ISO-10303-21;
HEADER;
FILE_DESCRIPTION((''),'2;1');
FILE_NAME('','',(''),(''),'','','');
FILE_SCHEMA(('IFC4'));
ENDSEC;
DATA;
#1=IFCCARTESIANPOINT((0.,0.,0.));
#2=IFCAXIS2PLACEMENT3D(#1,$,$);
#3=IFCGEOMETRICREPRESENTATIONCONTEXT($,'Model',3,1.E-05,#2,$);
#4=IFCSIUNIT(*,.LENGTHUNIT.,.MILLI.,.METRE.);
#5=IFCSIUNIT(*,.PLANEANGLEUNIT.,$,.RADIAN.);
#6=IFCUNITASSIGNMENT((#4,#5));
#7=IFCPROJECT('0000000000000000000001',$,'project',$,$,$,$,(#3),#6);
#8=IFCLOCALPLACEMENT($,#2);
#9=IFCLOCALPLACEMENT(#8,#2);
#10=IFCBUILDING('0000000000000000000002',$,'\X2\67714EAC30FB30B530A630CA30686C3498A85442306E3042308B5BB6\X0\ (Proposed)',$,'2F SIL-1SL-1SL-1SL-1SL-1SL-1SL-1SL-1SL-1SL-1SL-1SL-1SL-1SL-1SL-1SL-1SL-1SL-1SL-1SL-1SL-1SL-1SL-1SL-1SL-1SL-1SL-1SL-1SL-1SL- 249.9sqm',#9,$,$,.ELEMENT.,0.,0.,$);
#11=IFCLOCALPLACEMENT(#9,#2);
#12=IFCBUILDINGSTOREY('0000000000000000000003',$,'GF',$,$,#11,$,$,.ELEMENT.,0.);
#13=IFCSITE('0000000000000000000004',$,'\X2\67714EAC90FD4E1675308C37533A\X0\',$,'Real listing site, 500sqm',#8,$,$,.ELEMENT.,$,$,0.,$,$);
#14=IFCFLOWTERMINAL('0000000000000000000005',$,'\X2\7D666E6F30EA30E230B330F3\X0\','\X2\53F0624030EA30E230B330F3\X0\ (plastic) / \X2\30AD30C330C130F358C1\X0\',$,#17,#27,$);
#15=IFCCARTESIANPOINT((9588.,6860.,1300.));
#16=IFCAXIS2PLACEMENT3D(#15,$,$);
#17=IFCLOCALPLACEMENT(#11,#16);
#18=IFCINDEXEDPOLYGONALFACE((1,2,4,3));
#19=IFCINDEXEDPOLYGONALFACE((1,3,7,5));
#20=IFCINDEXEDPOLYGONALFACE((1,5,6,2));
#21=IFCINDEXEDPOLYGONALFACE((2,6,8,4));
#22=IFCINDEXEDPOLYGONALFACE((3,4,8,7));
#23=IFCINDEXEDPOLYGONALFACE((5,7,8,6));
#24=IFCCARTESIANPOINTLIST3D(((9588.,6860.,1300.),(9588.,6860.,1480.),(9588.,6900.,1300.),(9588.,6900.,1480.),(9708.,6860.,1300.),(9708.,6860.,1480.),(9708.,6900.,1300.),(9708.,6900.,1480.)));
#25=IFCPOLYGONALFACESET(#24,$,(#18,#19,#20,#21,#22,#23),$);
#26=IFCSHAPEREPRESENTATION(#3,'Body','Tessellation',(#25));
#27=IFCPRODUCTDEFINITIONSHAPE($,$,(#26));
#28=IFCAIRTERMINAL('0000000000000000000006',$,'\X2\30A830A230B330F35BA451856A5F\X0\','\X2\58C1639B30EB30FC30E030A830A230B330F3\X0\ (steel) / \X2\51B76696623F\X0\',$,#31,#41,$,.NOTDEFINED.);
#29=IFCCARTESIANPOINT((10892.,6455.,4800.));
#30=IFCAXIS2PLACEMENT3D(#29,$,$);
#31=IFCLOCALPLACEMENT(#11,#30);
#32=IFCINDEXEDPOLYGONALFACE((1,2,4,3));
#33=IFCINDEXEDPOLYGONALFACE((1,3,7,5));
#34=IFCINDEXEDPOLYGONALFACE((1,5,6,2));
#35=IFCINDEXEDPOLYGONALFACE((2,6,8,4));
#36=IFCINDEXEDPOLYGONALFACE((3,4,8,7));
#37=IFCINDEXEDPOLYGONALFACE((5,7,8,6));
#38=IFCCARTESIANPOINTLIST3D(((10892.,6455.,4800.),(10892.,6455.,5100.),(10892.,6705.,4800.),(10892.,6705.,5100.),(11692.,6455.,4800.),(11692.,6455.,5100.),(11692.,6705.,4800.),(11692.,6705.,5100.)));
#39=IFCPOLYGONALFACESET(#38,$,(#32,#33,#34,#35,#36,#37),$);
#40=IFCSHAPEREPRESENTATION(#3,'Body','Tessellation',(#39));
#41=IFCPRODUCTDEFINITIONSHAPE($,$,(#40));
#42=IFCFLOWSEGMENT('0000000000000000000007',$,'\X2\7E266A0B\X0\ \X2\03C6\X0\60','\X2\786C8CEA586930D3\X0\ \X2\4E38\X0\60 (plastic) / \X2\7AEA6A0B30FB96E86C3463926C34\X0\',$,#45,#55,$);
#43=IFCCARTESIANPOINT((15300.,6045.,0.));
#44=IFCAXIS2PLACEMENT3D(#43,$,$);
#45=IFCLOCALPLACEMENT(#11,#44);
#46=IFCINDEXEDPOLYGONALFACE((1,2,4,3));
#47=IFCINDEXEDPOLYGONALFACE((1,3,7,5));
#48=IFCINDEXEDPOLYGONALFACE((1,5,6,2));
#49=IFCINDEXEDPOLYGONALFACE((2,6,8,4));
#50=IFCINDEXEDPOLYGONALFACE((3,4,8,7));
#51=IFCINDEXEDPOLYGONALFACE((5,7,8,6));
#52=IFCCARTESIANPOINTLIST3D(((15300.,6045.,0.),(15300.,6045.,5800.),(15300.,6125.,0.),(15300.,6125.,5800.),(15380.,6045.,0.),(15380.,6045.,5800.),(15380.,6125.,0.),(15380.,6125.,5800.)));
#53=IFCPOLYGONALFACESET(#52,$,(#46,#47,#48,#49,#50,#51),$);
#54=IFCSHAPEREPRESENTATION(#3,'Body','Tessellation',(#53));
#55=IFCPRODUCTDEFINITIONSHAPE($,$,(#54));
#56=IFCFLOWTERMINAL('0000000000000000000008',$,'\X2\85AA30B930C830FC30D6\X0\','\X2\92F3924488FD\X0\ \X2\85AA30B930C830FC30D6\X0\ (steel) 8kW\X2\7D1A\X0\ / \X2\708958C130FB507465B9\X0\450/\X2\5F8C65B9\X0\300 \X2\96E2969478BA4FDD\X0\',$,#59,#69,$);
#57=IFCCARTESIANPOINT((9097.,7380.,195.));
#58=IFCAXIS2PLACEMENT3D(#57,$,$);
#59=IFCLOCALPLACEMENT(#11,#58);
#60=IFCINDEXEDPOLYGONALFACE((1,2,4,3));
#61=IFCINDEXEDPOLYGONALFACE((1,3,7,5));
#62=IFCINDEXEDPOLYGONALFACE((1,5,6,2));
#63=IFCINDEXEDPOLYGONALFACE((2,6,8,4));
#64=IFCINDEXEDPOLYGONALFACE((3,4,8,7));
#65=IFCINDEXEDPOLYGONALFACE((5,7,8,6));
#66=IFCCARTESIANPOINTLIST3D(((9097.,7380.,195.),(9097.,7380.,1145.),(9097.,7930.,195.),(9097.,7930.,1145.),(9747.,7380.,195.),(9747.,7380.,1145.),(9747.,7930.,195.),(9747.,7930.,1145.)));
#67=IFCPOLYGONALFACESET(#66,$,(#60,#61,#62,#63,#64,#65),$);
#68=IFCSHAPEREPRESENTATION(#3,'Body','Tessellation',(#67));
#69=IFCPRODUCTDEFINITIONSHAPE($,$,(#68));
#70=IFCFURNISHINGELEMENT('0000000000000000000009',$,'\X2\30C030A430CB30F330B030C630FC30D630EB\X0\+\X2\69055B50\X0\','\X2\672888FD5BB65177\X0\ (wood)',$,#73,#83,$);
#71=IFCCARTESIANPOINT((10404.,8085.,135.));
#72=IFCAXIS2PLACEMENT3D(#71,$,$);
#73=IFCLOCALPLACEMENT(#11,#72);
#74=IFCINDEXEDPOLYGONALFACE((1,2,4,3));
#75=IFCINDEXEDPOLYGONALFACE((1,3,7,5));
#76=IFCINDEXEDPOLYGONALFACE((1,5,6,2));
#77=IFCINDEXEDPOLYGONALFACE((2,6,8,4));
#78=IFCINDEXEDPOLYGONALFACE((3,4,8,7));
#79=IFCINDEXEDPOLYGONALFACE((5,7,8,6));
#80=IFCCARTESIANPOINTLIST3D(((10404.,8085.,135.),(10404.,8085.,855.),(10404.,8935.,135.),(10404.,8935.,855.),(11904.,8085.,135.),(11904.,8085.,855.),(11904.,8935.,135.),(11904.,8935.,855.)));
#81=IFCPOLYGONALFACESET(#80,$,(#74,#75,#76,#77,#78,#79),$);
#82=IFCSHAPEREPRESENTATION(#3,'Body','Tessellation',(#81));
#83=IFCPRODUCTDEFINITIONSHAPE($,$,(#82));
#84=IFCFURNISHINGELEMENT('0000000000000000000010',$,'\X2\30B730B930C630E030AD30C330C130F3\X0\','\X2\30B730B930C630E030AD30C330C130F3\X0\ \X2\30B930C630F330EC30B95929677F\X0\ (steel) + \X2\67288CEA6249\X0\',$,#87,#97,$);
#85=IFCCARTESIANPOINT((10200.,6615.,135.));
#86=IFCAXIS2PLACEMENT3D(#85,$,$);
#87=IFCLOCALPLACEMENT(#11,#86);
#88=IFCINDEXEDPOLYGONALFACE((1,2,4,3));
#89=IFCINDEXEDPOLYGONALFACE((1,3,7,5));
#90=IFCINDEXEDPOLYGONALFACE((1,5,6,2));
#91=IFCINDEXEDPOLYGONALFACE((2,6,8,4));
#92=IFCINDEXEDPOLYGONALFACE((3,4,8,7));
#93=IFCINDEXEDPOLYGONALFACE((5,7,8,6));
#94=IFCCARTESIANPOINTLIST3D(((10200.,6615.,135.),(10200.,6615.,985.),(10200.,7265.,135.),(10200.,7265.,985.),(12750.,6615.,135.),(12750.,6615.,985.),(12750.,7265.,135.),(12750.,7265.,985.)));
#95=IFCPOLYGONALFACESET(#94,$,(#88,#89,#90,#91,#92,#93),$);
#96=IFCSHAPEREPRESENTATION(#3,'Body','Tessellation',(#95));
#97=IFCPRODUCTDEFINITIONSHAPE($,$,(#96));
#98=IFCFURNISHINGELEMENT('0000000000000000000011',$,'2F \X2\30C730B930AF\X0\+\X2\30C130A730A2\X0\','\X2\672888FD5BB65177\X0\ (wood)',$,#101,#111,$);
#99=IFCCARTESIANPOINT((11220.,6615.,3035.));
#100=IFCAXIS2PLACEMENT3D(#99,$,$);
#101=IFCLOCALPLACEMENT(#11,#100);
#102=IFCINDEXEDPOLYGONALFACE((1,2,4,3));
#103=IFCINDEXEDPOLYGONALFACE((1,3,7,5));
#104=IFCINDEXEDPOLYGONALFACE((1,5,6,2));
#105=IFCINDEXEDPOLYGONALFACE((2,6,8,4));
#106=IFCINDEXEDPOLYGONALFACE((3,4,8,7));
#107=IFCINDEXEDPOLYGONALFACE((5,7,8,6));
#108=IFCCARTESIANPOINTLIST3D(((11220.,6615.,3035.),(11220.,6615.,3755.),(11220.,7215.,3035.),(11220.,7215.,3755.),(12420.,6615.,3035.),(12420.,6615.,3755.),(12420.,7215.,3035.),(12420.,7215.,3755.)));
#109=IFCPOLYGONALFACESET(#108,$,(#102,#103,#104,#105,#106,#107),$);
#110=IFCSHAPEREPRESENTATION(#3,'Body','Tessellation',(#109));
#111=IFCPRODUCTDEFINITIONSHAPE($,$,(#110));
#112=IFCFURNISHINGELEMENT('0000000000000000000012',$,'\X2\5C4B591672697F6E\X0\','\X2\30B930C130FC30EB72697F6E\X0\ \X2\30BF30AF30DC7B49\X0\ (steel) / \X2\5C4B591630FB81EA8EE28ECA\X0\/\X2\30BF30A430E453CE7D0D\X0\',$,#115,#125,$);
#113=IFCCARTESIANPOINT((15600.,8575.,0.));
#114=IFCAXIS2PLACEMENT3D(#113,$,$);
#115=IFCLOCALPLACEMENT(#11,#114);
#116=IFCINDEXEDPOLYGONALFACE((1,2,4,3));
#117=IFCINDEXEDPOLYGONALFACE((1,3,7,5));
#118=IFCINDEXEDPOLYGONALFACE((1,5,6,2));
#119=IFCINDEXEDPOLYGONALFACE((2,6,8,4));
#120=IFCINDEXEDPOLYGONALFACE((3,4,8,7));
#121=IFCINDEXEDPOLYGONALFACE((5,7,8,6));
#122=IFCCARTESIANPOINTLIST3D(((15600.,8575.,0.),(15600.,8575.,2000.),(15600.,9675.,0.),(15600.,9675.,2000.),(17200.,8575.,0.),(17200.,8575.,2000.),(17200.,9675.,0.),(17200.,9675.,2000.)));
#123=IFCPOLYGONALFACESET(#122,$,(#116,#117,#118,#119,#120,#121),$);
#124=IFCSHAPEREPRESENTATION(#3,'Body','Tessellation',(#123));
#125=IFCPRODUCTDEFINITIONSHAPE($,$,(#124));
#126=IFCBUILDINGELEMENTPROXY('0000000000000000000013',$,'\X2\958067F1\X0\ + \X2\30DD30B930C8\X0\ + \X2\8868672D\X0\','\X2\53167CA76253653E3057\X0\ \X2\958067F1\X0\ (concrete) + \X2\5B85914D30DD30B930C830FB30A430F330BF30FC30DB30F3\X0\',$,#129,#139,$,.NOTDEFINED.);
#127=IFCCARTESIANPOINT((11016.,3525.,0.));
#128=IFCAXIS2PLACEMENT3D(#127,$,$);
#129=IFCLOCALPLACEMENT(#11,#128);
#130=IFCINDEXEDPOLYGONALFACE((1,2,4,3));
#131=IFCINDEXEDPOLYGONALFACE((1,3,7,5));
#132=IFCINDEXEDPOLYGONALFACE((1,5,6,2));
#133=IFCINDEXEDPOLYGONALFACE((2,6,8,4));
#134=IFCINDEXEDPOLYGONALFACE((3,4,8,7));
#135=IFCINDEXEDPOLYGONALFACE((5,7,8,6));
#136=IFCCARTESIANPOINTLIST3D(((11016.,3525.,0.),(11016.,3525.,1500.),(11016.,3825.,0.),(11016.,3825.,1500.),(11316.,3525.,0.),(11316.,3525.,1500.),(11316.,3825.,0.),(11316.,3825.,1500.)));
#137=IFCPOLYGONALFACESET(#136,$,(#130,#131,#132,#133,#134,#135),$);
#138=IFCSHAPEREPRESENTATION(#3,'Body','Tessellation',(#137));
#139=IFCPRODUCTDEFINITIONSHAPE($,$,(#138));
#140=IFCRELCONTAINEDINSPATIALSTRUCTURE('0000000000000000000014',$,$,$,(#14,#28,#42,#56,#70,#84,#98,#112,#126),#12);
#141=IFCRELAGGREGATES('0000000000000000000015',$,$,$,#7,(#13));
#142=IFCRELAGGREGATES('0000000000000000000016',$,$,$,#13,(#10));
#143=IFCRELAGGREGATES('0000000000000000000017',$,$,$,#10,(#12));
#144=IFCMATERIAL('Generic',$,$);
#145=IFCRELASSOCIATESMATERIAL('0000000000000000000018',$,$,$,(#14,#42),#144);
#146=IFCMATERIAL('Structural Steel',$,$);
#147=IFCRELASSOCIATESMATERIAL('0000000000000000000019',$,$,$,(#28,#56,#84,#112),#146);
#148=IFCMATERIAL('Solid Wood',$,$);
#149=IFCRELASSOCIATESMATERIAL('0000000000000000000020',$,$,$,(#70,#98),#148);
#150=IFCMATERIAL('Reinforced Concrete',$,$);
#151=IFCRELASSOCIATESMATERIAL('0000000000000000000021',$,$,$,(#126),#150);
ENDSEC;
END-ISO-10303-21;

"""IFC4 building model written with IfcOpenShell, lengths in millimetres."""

from ifc_helpers import new_model, si_unit, frame, frame_2d, origin, place, context, project, spatial, rectangle, extrude, material, element, save


model = new_model("IFC4")

# Units and contexts
model_context = context("Model", 3, precision=1e-05, world=origin())
ifc_project = project(units=[si_unit("LENGTHUNIT", "METRE", prefix="MILLI"), si_unit("PLANEANGLEUNIT", "RADIAN")], contexts=[model_context])

# Site, building, storey
site_placement = place(None, origin())
site = spatial("IfcSite", under=ifc_project, at=site_placement, Name="東京都世田谷区", ObjectType="Real listing site, 500sqm", CompositionType="ELEMENT", RefElevation=0.0)
building_placement = place(site_placement, origin())
building = spatial("IfcBuilding", under=site, at=building_placement, Name="東京・サウナと水風呂のある家 (Proposed)", ObjectType="2F SIL-1SL-1SL-1SL-1SL-1SL-1SL-1SL-1SL-1SL-1SL-1SL-1SL-1SL-1SL-1SL-1SL-1SL-1SL-1SL-1SL-1SL-1SL-1SL-1SL-1SL-1SL-1SL-1SL-1SL- 249.9sqm", CompositionType="ELEMENT", ElevationOfRefHeight=0.0, ElevationOfTerrain=0.0)
storey_placement = place(building_placement, origin())
storey = spatial("IfcBuildingStorey", under=building, at=storey_placement, Name="GF", CompositionType="ELEMENT", Elevation=0.0)

# Shared definitions
ifc_material_1 = material(Name="Solid Wood")

# Shared definitions
ifc_material_2 = material(Name="Structural Steel")

# Shared definitions
ifc_material_3 = material(Name="Reinforced Concrete")

# Flow terminal
ifc_material_4 = material(Name="Generic")
flow_terminal_1_placement = place(storey_placement, frame((9588.0, 6860.0, 1300.0)))
element("IfcFlowTerminal", 1, at=flow_terminal_1_placement, inside=storey, material=ifc_material_4, Name="給湯リモコン", Description="台所リモコン (plastic) / キッチン壁", context=model_context, shape_type="SweptSolid", body=[
    extrude(rectangle(XDim=120.0, YDim=40.0, at=frame_2d((60.0, 20.0))), frame((9588.0, 6860.0, 1300.0)), (0.0, 0.0, 1.0), 180.0),
])

# Air terminal
air_terminal_placement = place(storey_placement, frame((10892.0, 6455.0, 4800.0)))
element("IfcAirTerminal", 2, at=air_terminal_placement, inside=storey, material=ifc_material_2, Name="エアコン室内機", Description="壁掛ルームエアコン (steel) / 冷暖房", PredefinedType="NOTDEFINED", context=model_context, shape_type="SweptSolid", body=[
    extrude(rectangle(XDim=800.0, YDim=250.0, at=frame_2d((400.0, 125.0))), frame((10892.0, 6455.0, 4800.0)), (0.0, 0.0, 1.0), 300.0),
])

# Flow segment
flow_segment_placement = place(storey_placement, frame((15300.0, 6045.0, 0.0)))
element("IfcFlowSegment", 3, at=flow_segment_placement, inside=storey, material=ifc_material_4, Name="縦樋 φ60", Description="硬質塩ビ 丸60 (plastic) / 竪樋・雨水排水", context=model_context, shape_type="SweptSolid", body=[
    extrude(rectangle(XDim=80.0, YDim=80.0, at=frame_2d((40.0, 40.0))), frame((15300.0, 6045.0, 0.0)), (0.0, 0.0, 1.0), 5800.0),
])

# Flow terminal
flow_terminal_2_placement = place(storey_placement, frame((9097.0, 7380.0, 195.0)))
element("IfcFlowTerminal", 4, at=flow_terminal_2_placement, inside=storey, material=ifc_material_2, Name="薪ストーブ", Description="鋳鉄製 薪ストーブ (steel) 8kW級 / 炉壁・側方450/後方300 離隔確保", context=model_context, shape_type="SweptSolid", body=[
    extrude(rectangle(XDim=650.0, YDim=550.0, at=frame_2d((325.0, 275.0))), frame((9097.0, 7380.0, 195.0)), (0.0, 0.0, 1.0), 950.0),
])

# Furnishing elements
furnishing_1_placement = place(storey_placement, frame((10404.0, 8085.0, 135.0)))
element("IfcFurnishingElement", 5, at=furnishing_1_placement, inside=storey, material=ifc_material_1, Name="ダイニングテーブル+椅子", Description="木製家具 (wood)", context=model_context, shape_type="SweptSolid", body=[
    extrude(rectangle(XDim=1500.0, YDim=850.0, at=frame_2d((750.0, 425.0))), frame((10404.0, 8085.0, 135.0)), (0.0, 0.0, 1.0), 720.0),
])
furnishing_2_placement = place(storey_placement, frame((10200.0, 6615.0, 135.0)))
element("IfcFurnishingElement", 6, at=furnishing_2_placement, inside=storey, material=ifc_material_2, Name="システムキッチン", Description="システムキッチン ステンレス天板 (steel) + 木質扉", context=model_context, shape_type="SweptSolid", body=[
    extrude(rectangle(XDim=2550.0, YDim=650.0, at=frame_2d((1275.0, 325.0))), frame((10200.0, 6615.0, 135.0)), (0.0, 0.0, 1.0), 850.0),
])
furnishing_3_placement = place(storey_placement, frame((11220.0, 6615.0, 3035.0)))
element("IfcFurnishingElement", 7, at=furnishing_3_placement, inside=storey, material=ifc_material_1, Name="2F デスク+チェア", Description="木製家具 (wood)", context=model_context, shape_type="SweptSolid", body=[
    extrude(rectangle(XDim=1200.0, YDim=600.0, at=frame_2d((600.0, 300.0))), frame((11220.0, 6615.0, 3035.0)), (0.0, 0.0, 1.0), 720.0),
])
furnishing_4_placement = place(storey_placement, frame((15600.0, 8575.0, 0.0)))
element("IfcFurnishingElement", 8, at=furnishing_4_placement, inside=storey, material=ifc_material_2, Name="屋外物置", Description="スチール物置 タクボ等 (steel) / 屋外・自転車/タイヤ収納", context=model_context, shape_type="SweptSolid", body=[
    extrude(rectangle(XDim=1600.0, YDim=1100.0, at=frame_2d((800.0, 550.0))), frame((15600.0, 8575.0, 0.0)), (0.0, 0.0, 1.0), 2000.0),
])

# Building element proxy
proxy_placement = place(storey_placement, frame((11016.0, 3525.0, 0.0)))
element("IfcBuildingElementProxy", 9, at=proxy_placement, inside=storey, material=ifc_material_3, Name="門柱 + ポスト + 表札", Description="化粧打放し 門柱 (concrete) + 宅配ポスト・インターホン", PredefinedType="NOTDEFINED", context=model_context, shape_type="SweptSolid", body=[
    extrude(rectangle(XDim=300.0, YDim=300.0, at=frame_2d((150.0, 150.0))), frame((11016.0, 3525.0, 0.0)), (0.0, 0.0, 1.0), 1500.0),
])

save(model, "model.ifc")
